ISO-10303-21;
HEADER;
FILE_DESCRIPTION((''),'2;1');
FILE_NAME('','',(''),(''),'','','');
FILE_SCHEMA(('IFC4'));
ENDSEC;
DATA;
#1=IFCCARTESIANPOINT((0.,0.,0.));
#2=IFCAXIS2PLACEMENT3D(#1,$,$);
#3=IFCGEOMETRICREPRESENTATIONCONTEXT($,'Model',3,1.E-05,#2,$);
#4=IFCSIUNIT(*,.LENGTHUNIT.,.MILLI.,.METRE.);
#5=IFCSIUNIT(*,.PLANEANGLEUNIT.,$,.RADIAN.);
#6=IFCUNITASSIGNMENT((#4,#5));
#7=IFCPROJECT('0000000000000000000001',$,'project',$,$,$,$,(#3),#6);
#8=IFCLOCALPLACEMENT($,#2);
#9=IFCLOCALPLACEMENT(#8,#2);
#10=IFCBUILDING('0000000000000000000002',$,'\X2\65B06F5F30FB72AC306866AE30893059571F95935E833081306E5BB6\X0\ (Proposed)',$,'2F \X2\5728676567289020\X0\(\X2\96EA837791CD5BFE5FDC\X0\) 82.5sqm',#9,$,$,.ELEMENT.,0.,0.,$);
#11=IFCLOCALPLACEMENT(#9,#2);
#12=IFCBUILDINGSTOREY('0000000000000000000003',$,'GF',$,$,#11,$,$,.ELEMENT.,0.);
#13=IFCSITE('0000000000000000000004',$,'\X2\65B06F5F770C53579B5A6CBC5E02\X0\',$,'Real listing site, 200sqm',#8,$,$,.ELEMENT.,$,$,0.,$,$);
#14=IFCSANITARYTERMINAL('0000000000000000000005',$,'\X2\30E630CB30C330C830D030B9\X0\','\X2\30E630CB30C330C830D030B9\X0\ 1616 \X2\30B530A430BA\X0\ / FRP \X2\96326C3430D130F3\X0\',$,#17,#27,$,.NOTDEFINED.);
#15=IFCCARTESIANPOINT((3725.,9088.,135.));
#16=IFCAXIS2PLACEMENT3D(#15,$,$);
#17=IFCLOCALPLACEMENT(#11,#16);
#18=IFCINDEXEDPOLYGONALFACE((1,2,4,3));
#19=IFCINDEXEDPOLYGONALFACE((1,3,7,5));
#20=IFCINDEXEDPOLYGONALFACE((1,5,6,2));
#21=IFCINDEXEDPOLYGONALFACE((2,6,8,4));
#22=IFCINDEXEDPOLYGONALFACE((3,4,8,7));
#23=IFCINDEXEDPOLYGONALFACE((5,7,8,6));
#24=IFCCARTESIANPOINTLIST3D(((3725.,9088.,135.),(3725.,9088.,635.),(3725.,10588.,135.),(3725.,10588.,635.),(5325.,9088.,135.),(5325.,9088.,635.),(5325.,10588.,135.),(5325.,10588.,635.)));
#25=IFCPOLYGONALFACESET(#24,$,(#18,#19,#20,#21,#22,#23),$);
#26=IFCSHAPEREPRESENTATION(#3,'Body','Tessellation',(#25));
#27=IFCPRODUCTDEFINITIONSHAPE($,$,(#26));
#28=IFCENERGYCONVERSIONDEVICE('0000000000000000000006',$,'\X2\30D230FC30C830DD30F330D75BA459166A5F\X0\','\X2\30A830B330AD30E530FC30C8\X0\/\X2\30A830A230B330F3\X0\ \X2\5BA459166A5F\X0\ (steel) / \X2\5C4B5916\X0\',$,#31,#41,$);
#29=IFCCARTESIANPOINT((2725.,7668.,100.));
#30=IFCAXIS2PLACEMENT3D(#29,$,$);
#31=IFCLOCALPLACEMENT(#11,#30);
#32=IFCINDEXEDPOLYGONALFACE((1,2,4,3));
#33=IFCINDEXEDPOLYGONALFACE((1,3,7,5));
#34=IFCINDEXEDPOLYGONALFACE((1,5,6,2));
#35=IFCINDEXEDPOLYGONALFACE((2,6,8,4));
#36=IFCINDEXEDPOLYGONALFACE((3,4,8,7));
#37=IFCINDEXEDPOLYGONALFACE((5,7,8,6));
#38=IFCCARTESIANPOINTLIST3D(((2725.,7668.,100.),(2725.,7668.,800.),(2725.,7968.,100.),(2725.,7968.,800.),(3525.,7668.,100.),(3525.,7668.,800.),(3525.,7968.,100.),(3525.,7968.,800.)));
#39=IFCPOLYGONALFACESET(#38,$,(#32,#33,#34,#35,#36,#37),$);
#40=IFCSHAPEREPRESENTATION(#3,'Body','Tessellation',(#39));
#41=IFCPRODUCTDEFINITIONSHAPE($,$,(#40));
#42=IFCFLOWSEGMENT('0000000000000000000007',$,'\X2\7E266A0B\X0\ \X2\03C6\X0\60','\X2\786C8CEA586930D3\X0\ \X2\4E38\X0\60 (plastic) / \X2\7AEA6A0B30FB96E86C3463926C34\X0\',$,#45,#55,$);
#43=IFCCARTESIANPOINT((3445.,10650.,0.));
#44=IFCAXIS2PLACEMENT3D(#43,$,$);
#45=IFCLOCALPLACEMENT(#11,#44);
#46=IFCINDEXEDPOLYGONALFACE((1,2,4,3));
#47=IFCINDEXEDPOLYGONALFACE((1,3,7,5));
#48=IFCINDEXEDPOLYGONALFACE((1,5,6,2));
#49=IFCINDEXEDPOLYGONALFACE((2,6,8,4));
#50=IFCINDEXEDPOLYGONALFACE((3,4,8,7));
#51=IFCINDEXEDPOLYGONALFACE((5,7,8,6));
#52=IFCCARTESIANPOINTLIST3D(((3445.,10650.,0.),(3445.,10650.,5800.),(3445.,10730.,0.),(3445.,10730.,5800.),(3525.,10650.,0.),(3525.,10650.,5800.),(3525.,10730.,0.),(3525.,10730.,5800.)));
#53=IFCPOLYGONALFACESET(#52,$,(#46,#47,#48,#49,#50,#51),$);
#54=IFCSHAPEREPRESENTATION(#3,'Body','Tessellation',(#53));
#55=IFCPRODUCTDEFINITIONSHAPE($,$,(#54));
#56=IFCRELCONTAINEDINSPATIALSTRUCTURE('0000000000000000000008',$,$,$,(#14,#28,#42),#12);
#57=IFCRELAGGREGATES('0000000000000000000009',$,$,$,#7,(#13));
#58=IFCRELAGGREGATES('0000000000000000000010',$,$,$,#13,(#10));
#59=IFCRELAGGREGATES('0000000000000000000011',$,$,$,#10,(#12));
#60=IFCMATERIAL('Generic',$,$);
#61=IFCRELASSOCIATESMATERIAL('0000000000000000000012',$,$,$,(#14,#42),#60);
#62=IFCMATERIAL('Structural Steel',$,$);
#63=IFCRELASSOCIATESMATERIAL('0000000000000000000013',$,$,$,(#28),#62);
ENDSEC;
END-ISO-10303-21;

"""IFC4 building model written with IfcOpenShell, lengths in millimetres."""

from ifc_helpers import new_model, si_unit, frame, frame_2d, origin, place, context, project, spatial, rectangle, extrude, material, element, save


model = new_model("IFC4")

# Units and contexts
model_context = context("Model", 3, precision=1e-05, world=origin())
ifc_project = project(units=[si_unit("LENGTHUNIT", "METRE", prefix="MILLI"), si_unit("PLANEANGLEUNIT", "RADIAN")], contexts=[model_context])

# Site, building, storey
site_placement = place(None, origin())
site = spatial("IfcSite", under=ifc_project, at=site_placement, Name="新潟県南魚沼市", ObjectType="Real listing site, 200sqm", CompositionType="ELEMENT", RefElevation=0.0)
building_placement = place(site_placement, origin())
building = spatial("IfcBuilding", under=site, at=building_placement, Name="新潟・犬と暮らす土間広めの家 (Proposed)", ObjectType="2F 在来木造(雪荷重対応) 82.5sqm", CompositionType="ELEMENT", ElevationOfRefHeight=0.0, ElevationOfTerrain=0.0)
storey_placement = place(building_placement, origin())
storey = spatial("IfcBuildingStorey", under=building, at=storey_placement, Name="GF", CompositionType="ELEMENT", Elevation=0.0)

# Shared definitions
ifc_material_1 = material(Name="Generic")

# Sanitary terminal
sanitary_terminal_placement = place(storey_placement, frame((3725.0, 9088.0, 135.0)))
element("IfcSanitaryTerminal", 1, at=sanitary_terminal_placement, inside=storey, material=ifc_material_1, Name="ユニットバス", Description="ユニットバス 1616 サイズ / FRP 防水パン", PredefinedType="NOTDEFINED", context=model_context, shape_type="SweptSolid", body=[
    extrude(rectangle(XDim=1600.0, YDim=1500.0, at=frame_2d((800.0, 750.0))), frame((3725.0, 9088.0, 135.0)), (0.0, 0.0, 1.0), 500.0),
])

# Energy conversion device
ifc_material_2 = material(Name="Structural Steel")
energy_conversion_device_placement = place(storey_placement, frame((2725.0, 7668.0, 100.0)))
element("IfcEnergyConversionDevice", 2, at=energy_conversion_device_placement, inside=storey, material=ifc_material_2, Name="ヒートポンプ室外機", Description="エコキュート/エアコン 室外機 (steel) / 屋外", context=model_context, shape_type="SweptSolid", body=[
    extrude(rectangle(XDim=800.0, YDim=300.0, at=frame_2d((400.0, 150.0))), frame((2725.0, 7668.0, 100.0)), (0.0, 0.0, 1.0), 700.0),
])

# Flow segment
flow_segment_placement = place(storey_placement, frame((3445.0, 10650.0, 0.0)))
element("IfcFlowSegment", 3, at=flow_segment_placement, inside=storey, material=ifc_material_1, Name="縦樋 φ60", Description="硬質塩ビ 丸60 (plastic) / 竪樋・雨水排水", context=model_context, shape_type="SweptSolid", body=[
    extrude(rectangle(XDim=80.0, YDim=80.0, at=frame_2d((40.0, 40.0))), frame((3445.0, 10650.0, 0.0)), (0.0, 0.0, 1.0), 5800.0),
])

save(model, "model.ifc")
